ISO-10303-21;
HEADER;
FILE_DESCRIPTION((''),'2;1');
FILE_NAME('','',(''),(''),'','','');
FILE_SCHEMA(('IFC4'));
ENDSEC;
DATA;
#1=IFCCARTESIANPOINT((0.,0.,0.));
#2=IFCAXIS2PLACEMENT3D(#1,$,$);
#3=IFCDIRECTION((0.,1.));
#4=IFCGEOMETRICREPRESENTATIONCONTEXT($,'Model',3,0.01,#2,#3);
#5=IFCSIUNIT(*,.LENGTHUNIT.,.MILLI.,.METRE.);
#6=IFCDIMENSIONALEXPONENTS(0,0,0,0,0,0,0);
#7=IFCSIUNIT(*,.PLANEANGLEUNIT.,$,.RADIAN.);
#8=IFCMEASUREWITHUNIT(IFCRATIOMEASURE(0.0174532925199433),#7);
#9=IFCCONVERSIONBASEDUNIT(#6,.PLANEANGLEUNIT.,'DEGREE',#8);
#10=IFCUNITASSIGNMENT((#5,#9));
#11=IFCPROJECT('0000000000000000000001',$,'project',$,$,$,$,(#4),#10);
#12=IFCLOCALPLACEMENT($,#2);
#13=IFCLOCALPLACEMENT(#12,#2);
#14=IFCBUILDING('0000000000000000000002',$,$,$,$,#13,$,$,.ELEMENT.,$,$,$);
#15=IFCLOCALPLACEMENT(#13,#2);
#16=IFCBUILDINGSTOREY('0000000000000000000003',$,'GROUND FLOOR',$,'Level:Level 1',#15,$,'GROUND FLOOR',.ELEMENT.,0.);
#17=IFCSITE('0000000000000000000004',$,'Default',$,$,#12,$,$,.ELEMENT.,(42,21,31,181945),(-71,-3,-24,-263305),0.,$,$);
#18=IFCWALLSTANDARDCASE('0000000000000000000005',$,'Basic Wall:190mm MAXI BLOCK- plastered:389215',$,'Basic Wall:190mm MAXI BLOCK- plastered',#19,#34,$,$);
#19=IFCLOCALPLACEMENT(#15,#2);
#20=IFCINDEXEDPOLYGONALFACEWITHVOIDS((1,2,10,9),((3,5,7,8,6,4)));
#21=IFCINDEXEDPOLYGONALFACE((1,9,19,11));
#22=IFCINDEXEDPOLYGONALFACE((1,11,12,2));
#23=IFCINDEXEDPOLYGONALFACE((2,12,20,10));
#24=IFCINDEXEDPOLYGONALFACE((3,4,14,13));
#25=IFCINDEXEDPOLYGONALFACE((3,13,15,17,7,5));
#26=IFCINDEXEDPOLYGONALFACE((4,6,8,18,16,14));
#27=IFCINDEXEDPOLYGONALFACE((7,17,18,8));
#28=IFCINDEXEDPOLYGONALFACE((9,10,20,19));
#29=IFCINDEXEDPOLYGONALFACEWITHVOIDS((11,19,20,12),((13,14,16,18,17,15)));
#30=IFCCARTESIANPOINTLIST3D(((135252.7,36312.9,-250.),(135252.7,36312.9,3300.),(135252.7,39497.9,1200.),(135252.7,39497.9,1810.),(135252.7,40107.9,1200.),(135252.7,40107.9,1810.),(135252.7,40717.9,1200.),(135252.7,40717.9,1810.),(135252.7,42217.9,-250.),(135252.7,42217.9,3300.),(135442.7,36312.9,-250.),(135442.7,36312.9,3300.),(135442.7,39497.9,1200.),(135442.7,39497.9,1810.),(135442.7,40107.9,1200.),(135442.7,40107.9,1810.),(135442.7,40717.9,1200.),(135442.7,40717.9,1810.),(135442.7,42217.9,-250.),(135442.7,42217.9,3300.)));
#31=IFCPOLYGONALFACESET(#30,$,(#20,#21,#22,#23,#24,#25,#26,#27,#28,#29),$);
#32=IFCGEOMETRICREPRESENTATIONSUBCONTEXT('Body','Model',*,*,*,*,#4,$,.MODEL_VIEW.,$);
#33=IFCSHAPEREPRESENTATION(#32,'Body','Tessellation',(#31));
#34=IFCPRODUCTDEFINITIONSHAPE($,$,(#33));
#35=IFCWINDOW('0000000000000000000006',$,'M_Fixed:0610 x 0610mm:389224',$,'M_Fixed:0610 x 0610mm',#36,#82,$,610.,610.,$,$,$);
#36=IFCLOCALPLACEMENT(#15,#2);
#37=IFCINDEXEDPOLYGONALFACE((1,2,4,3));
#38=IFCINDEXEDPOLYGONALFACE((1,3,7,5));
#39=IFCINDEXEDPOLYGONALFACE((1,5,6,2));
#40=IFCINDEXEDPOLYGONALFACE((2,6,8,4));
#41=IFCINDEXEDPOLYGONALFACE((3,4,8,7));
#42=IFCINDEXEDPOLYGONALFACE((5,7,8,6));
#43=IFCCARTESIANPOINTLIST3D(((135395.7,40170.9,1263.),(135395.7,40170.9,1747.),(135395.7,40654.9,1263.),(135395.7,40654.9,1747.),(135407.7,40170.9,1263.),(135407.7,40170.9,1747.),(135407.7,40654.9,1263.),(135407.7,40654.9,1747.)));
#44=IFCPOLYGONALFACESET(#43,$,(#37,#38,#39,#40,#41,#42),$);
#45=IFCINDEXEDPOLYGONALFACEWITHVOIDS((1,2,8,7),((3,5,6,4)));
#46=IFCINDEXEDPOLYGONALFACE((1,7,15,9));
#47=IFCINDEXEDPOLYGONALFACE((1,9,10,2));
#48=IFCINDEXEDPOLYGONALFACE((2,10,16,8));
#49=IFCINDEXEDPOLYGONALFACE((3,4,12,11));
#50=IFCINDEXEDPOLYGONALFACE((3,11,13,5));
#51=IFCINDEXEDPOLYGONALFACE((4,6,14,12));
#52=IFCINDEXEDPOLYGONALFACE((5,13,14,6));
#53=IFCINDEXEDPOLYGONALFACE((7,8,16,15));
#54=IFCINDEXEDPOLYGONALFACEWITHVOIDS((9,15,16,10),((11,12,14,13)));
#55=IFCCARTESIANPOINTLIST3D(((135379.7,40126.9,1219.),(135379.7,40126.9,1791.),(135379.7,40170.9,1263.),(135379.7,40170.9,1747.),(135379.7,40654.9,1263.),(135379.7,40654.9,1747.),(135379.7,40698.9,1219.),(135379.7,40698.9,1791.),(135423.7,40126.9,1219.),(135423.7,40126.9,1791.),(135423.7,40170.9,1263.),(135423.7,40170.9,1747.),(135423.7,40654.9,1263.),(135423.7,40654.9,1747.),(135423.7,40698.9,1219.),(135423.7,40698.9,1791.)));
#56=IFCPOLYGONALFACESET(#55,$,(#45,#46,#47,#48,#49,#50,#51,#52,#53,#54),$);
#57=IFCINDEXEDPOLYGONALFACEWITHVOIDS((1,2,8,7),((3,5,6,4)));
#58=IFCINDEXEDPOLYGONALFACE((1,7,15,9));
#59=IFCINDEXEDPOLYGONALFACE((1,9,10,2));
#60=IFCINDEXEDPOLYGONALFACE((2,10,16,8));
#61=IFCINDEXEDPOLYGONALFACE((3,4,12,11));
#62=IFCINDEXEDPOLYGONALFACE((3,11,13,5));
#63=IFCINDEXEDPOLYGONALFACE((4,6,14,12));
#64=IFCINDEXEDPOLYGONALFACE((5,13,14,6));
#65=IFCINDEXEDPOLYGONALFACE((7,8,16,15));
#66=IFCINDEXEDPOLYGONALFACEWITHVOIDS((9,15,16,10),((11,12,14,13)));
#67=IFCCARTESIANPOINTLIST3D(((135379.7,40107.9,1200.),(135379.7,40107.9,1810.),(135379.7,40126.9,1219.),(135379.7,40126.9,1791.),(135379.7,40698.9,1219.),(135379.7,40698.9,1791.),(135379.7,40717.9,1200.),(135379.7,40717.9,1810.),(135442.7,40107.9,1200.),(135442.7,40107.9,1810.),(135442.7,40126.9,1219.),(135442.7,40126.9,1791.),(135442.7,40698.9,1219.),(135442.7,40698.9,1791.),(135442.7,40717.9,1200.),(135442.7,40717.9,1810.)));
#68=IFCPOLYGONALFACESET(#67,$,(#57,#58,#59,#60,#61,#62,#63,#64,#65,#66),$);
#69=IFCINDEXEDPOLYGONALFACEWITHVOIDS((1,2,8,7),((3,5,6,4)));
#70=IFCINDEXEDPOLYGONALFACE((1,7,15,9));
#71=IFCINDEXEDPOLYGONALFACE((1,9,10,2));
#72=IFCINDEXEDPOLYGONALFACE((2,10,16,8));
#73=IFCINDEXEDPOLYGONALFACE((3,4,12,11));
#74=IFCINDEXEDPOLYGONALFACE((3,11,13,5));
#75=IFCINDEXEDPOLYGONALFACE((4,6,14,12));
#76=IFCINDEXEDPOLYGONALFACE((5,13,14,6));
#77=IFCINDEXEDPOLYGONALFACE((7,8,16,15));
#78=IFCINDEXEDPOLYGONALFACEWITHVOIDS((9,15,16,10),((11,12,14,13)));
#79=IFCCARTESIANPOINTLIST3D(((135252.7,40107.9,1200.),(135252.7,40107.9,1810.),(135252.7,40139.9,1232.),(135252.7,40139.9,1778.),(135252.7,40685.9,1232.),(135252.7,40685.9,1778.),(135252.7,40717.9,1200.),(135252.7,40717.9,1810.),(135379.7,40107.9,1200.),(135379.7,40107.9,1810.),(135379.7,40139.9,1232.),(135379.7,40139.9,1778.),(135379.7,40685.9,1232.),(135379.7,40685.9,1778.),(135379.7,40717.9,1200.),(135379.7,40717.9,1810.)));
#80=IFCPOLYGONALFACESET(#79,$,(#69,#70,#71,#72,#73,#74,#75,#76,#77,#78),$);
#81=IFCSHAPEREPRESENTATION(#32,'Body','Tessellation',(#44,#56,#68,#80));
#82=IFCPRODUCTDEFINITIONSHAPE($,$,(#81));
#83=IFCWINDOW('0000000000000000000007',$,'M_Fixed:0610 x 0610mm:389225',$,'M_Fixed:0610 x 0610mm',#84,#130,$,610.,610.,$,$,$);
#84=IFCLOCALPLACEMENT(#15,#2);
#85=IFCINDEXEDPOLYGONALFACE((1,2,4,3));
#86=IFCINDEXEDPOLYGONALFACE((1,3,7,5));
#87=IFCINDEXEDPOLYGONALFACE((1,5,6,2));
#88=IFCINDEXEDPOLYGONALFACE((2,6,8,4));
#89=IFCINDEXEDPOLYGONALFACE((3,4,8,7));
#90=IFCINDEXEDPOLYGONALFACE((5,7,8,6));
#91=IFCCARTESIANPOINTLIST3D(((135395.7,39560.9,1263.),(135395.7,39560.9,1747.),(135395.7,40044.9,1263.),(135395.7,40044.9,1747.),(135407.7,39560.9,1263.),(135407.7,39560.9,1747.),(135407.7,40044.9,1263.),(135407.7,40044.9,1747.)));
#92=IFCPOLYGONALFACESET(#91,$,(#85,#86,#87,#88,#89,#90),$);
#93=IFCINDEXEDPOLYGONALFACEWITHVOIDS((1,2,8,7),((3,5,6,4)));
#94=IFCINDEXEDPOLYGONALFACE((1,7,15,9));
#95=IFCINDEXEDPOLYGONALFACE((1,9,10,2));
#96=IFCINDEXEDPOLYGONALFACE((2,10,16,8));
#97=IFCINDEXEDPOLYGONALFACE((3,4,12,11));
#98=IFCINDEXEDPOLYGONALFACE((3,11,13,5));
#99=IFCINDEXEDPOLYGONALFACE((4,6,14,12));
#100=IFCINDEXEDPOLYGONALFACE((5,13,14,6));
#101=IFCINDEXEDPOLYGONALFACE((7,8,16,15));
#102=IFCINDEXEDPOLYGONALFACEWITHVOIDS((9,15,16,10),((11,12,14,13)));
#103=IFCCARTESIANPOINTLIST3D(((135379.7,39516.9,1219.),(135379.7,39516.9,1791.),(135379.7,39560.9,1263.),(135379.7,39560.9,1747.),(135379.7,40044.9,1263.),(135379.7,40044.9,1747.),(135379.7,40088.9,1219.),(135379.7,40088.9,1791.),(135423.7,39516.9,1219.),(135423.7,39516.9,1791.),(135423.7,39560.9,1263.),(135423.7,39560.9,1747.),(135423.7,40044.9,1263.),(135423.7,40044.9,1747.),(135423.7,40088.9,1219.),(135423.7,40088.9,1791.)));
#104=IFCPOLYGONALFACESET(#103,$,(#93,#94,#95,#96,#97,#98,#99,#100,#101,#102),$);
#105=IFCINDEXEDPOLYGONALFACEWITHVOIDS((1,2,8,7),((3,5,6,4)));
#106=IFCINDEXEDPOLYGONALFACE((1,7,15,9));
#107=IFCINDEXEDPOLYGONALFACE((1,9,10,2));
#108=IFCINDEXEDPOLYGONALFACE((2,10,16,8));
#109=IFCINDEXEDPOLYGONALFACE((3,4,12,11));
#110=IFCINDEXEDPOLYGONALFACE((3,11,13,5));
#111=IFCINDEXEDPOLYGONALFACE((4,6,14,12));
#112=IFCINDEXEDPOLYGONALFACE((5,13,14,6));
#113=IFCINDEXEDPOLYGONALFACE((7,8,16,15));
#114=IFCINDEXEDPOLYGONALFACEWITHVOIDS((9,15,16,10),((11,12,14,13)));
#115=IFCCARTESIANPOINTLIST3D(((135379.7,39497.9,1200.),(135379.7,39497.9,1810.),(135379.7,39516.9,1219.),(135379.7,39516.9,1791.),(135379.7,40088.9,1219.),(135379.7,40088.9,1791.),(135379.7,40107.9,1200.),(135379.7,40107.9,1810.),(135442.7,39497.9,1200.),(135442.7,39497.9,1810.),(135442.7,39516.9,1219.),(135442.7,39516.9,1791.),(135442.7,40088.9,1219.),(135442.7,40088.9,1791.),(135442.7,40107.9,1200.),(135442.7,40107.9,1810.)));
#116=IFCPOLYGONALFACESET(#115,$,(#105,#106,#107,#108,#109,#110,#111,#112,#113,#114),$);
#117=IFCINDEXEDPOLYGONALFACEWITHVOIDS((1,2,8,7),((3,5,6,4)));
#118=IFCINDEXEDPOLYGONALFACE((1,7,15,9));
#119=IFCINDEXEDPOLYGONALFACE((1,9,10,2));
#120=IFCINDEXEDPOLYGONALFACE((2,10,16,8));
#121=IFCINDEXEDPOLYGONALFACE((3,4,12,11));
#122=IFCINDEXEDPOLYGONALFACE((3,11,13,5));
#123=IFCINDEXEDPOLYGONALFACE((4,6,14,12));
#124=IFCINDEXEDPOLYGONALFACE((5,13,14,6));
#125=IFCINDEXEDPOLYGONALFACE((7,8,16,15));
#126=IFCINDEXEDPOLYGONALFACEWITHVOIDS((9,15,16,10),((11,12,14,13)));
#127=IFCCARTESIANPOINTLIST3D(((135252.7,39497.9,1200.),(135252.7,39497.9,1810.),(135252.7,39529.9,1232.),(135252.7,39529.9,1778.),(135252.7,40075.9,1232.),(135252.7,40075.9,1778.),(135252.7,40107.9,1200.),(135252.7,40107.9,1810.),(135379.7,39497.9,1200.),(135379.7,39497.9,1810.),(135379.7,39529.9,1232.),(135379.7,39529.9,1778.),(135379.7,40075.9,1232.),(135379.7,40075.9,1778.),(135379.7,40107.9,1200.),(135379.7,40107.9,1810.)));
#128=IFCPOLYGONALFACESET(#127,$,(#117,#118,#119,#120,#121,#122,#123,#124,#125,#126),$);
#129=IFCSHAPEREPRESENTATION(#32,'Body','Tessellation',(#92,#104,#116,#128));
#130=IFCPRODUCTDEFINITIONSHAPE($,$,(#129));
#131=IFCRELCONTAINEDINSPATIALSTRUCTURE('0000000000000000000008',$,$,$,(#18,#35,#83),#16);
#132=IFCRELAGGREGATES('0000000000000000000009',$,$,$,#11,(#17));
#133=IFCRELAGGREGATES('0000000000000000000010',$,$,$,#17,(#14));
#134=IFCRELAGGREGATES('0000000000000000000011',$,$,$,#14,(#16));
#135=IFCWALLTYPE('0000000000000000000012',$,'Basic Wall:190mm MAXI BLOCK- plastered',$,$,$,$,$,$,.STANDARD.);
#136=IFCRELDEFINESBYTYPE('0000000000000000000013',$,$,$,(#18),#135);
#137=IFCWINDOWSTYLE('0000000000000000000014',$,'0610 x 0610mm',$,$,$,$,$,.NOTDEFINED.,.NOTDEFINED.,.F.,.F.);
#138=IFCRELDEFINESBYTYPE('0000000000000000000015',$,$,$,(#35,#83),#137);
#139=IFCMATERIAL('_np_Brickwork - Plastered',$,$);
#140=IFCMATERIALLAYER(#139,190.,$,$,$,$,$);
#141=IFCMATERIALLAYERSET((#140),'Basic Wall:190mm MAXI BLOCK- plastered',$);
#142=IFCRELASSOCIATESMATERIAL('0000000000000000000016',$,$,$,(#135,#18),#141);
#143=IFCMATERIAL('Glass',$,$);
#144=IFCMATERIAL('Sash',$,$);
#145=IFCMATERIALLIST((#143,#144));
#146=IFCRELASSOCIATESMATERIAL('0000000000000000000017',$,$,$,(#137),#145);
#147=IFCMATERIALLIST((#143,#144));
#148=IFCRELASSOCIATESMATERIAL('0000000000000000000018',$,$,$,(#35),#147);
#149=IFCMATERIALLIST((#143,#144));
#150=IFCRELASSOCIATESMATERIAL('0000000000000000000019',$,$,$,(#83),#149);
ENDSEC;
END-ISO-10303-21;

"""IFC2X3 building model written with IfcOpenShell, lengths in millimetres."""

from ifc_helpers import new_model, entity, si_unit, converted_unit, direction, frame, frame_2d, origin, place, context, subcontext, project, spatial, polyline, rectangle, outline, extrude, source, transform, mapped, material, material_list, layer, layer_set, layer_usage, type_object, type_shapes, element, fill, save


model = new_model("IFC2X3")

# Units and contexts
model_context = context("Model", 3, precision=0.01, world=origin(), true_north=direction((0.0, 1.0)))
body_context = subcontext(model_context, "Body", "Model", "MODEL_VIEW")
ifc_project = project(units=[si_unit("LENGTHUNIT", "METRE", prefix="MILLI"), converted_unit("PLANEANGLEUNIT", "DEGREE", entity("IfcRatioMeasure", 0.0174532925199433), si_unit("PLANEANGLEUNIT", "RADIAN"), dimensions=[0, 0, 0, 0, 0, 0, 0])], contexts=[model_context])

# Site, building, storey
site_placement = place(None, origin())
site = spatial("IfcSite", under=ifc_project, at=site_placement, Name="Default", CompositionType="ELEMENT", RefLatitude=(42, 21, 31, 181945), RefLongitude=(-71, -3, -24, -263305), RefElevation=0.0)
building_placement = place(site_placement, origin())
building = spatial("IfcBuilding", under=site, at=building_placement, CompositionType="ELEMENT")
storey_placement = place(building_placement, origin())
storey = spatial("IfcBuildingStorey", under=building, at=storey_placement, Name="GROUND FLOOR", ObjectType="Level:Level 1", LongName="GROUND FLOOR", CompositionType="ELEMENT", Elevation=0.0)

# Wall, openings, windows
ifc_material_1 = material(Name="_np_Brickwork - Plastered")
ifc_layer = layer(ifc_material_1, 190.0)
ifc_layer_set = layer_set([ifc_layer], Name="Basic Wall:190mm MAXI BLOCK- plastered")
wall_type = type_object("IfcWallType", Name="Basic Wall:190mm MAXI BLOCK- plastered", PredefinedType="STANDARD", material=ifc_layer_set)
ifc_material_2 = material(Name="Glass")
ifc_material_3 = material(Name="Sash")
ifc_material_list_1 = material_list([ifc_material_2, ifc_material_3])
window_style = type_object("IfcWindowStyle", Name="0610 x 0610mm", ConstructionType="NOTDEFINED", OperationType="NOTDEFINED", ParameterTakesPrecedence=False, Sizeable=False, material=ifc_material_list_1)
shared_shape = source(origin(), body_context, "Body", "SweptSolid", [
    extrude(rectangle(XDim=12.0, YDim=484.0, at=frame_2d((0.0, 0.0), x_axis=(1.0, 0.0))), frame((305.0, 149.0, 63.0), z_axis=(0.0, 0.0, 1.0), x_axis=(0.0, -1.0, 0.0)), (0.0, 0.0, 1.0), 484.0),
    extrude(outline(polyline([(-286.0, -286.0), (286.0, -286.0), (286.0, 286.0), (-286.0, 286.0), (-286.0, -286.0)]), holes=[polyline([(-242.0, -242.0), (-242.0, 242.0), (242.0, 242.0), (242.0, -242.0), (-242.0, -242.0)])]), frame((305.0, 127.0, 305.0), z_axis=(0.0, 1.0, 0.0), x_axis=(1.0, 0.0, 0.0)), (0.0, 0.0, 1.0), 44.0),
    extrude(outline(polyline([(-305.0, -305.0), (305.0, -305.0), (305.0, 305.0), (-305.0, 305.0), (-305.0, -305.0)]), holes=[polyline([(-286.0, -286.0), (-286.0, 286.0), (286.0, 286.0), (286.0, -286.0), (-286.0, -286.0)])]), frame((305.0, 127.0, 305.0), z_axis=(0.0, 1.0, 0.0), x_axis=(1.0, 0.0, 0.0)), (0.0, 0.0, 1.0), 63.0),
    extrude(outline(polyline([(-305.0, -305.0), (305.0, -305.0), (305.0, 305.0), (-305.0, 305.0), (-305.0, -305.0)]), holes=[polyline([(-273.0, -273.0), (-273.0, 273.0), (273.0, 273.0), (273.0, -273.0), (-273.0, -273.0)])]), frame((305.0, 0.0, 305.0), z_axis=(0.0, 1.0, 0.0), x_axis=(1.0, 0.0, 0.0)), (0.0, 0.0, 1.0), 127.0),
])
type_shapes(window_style, [shared_shape])
ifc_layer_usage_1 = layer_usage(ifc_layer_set, "AXIS2", "NEGATIVE", 95.0)
wall_1_placement = place(storey_placement, frame((135347.7, 36312.9, -250.0), z_axis=(0.0, 0.0, 1.0), x_axis=(0.0, 1.0, 0.0)))
wall_1 = element("IfcWallStandardCase", 1, at=wall_1_placement, inside=storey, type_object=wall_type, material=ifc_layer_usage_1, Name="Basic Wall:190mm MAXI BLOCK- plastered:389215", ObjectType="Basic Wall:190mm MAXI BLOCK- plastered", context=body_context, shape_type="SweptSolid", body=[
    extrude(rectangle(XDim=5905.0, YDim=190.0, at=frame_2d((2952.5, 0.0), x_axis=(-1.0, 0.0))), origin(), (0.0, 0.0, 1.0), 3550.0),
])
opening_1_placement = place(wall_1_placement, frame((4405.0, 95.0, 1450.0)))
opening_1 = element("IfcOpeningElement", 2, at=opening_1_placement, cuts=wall_1, ObjectType="Opening", context=body_context, shape_type="SweptSolid", body=[
    extrude(rectangle(XDim=610.0, YDim=610.0, at=frame_2d((305.0, 305.0), x_axis=(1.0, 0.0))), frame((0.0, 0.0, 0.0), z_axis=(0.0, -1.0, 0.0), x_axis=(0.0, 0.0, 1.0)), (0.0, 0.0, 1.0), 190.0),
])
opening_2_placement = place(wall_1_placement, frame((3795.0, 95.0, 1450.0)))
opening_2 = element("IfcOpeningElement", 3, at=opening_2_placement, cuts=wall_1, ObjectType="Opening", context=body_context, shape_type="SweptSolid", body=[
    extrude(rectangle(XDim=610.0, YDim=610.0, at=frame_2d((305.0, 305.0), x_axis=(1.0, 0.0))), frame((0.0, 0.0, 0.0), z_axis=(0.0, -1.0, 0.0), x_axis=(0.0, 0.0, 1.0)), (0.0, 0.0, 1.0), 190.0),
])
ifc_material_list_2 = material_list([ifc_material_2, ifc_material_3])
window_1_placement = place(opening_1_placement, frame((0.0, 0.0, 0.0), z_axis=(0.0, 0.0, 1.0), x_axis=(-1.0, 0.0, 0.0)))
window_1 = element("IfcWindow", 4, at=window_1_placement, inside=storey, type_object=window_style, material=ifc_material_list_2, Name="M_Fixed:0610 x 0610mm:389224", ObjectType="M_Fixed:0610 x 0610mm", OverallHeight=610.0, OverallWidth=610.0, context=body_context, shape_type="MappedRepresentation", body=[
    mapped(shared_shape, transform((0.0, 0.0, 0.0), scale=1.0)),
])
fill(opening_1, window_1)
ifc_material_list_3 = material_list([ifc_material_2, ifc_material_3])
window_2_placement = place(opening_2_placement, frame((0.0, 0.0, 0.0), z_axis=(0.0, 0.0, 1.0), x_axis=(-1.0, 0.0, 0.0)))
window_2 = element("IfcWindow", 5, at=window_2_placement, inside=storey, type_object=window_style, material=ifc_material_list_3, Name="M_Fixed:0610 x 0610mm:389225", ObjectType="M_Fixed:0610 x 0610mm", OverallHeight=610.0, OverallWidth=610.0, context=body_context, shape_type="MappedRepresentation", body=[
    mapped(shared_shape, transform((0.0, 0.0, 0.0), scale=1.0)),
])
fill(opening_2, window_2)

save(model, "model.ifc")
